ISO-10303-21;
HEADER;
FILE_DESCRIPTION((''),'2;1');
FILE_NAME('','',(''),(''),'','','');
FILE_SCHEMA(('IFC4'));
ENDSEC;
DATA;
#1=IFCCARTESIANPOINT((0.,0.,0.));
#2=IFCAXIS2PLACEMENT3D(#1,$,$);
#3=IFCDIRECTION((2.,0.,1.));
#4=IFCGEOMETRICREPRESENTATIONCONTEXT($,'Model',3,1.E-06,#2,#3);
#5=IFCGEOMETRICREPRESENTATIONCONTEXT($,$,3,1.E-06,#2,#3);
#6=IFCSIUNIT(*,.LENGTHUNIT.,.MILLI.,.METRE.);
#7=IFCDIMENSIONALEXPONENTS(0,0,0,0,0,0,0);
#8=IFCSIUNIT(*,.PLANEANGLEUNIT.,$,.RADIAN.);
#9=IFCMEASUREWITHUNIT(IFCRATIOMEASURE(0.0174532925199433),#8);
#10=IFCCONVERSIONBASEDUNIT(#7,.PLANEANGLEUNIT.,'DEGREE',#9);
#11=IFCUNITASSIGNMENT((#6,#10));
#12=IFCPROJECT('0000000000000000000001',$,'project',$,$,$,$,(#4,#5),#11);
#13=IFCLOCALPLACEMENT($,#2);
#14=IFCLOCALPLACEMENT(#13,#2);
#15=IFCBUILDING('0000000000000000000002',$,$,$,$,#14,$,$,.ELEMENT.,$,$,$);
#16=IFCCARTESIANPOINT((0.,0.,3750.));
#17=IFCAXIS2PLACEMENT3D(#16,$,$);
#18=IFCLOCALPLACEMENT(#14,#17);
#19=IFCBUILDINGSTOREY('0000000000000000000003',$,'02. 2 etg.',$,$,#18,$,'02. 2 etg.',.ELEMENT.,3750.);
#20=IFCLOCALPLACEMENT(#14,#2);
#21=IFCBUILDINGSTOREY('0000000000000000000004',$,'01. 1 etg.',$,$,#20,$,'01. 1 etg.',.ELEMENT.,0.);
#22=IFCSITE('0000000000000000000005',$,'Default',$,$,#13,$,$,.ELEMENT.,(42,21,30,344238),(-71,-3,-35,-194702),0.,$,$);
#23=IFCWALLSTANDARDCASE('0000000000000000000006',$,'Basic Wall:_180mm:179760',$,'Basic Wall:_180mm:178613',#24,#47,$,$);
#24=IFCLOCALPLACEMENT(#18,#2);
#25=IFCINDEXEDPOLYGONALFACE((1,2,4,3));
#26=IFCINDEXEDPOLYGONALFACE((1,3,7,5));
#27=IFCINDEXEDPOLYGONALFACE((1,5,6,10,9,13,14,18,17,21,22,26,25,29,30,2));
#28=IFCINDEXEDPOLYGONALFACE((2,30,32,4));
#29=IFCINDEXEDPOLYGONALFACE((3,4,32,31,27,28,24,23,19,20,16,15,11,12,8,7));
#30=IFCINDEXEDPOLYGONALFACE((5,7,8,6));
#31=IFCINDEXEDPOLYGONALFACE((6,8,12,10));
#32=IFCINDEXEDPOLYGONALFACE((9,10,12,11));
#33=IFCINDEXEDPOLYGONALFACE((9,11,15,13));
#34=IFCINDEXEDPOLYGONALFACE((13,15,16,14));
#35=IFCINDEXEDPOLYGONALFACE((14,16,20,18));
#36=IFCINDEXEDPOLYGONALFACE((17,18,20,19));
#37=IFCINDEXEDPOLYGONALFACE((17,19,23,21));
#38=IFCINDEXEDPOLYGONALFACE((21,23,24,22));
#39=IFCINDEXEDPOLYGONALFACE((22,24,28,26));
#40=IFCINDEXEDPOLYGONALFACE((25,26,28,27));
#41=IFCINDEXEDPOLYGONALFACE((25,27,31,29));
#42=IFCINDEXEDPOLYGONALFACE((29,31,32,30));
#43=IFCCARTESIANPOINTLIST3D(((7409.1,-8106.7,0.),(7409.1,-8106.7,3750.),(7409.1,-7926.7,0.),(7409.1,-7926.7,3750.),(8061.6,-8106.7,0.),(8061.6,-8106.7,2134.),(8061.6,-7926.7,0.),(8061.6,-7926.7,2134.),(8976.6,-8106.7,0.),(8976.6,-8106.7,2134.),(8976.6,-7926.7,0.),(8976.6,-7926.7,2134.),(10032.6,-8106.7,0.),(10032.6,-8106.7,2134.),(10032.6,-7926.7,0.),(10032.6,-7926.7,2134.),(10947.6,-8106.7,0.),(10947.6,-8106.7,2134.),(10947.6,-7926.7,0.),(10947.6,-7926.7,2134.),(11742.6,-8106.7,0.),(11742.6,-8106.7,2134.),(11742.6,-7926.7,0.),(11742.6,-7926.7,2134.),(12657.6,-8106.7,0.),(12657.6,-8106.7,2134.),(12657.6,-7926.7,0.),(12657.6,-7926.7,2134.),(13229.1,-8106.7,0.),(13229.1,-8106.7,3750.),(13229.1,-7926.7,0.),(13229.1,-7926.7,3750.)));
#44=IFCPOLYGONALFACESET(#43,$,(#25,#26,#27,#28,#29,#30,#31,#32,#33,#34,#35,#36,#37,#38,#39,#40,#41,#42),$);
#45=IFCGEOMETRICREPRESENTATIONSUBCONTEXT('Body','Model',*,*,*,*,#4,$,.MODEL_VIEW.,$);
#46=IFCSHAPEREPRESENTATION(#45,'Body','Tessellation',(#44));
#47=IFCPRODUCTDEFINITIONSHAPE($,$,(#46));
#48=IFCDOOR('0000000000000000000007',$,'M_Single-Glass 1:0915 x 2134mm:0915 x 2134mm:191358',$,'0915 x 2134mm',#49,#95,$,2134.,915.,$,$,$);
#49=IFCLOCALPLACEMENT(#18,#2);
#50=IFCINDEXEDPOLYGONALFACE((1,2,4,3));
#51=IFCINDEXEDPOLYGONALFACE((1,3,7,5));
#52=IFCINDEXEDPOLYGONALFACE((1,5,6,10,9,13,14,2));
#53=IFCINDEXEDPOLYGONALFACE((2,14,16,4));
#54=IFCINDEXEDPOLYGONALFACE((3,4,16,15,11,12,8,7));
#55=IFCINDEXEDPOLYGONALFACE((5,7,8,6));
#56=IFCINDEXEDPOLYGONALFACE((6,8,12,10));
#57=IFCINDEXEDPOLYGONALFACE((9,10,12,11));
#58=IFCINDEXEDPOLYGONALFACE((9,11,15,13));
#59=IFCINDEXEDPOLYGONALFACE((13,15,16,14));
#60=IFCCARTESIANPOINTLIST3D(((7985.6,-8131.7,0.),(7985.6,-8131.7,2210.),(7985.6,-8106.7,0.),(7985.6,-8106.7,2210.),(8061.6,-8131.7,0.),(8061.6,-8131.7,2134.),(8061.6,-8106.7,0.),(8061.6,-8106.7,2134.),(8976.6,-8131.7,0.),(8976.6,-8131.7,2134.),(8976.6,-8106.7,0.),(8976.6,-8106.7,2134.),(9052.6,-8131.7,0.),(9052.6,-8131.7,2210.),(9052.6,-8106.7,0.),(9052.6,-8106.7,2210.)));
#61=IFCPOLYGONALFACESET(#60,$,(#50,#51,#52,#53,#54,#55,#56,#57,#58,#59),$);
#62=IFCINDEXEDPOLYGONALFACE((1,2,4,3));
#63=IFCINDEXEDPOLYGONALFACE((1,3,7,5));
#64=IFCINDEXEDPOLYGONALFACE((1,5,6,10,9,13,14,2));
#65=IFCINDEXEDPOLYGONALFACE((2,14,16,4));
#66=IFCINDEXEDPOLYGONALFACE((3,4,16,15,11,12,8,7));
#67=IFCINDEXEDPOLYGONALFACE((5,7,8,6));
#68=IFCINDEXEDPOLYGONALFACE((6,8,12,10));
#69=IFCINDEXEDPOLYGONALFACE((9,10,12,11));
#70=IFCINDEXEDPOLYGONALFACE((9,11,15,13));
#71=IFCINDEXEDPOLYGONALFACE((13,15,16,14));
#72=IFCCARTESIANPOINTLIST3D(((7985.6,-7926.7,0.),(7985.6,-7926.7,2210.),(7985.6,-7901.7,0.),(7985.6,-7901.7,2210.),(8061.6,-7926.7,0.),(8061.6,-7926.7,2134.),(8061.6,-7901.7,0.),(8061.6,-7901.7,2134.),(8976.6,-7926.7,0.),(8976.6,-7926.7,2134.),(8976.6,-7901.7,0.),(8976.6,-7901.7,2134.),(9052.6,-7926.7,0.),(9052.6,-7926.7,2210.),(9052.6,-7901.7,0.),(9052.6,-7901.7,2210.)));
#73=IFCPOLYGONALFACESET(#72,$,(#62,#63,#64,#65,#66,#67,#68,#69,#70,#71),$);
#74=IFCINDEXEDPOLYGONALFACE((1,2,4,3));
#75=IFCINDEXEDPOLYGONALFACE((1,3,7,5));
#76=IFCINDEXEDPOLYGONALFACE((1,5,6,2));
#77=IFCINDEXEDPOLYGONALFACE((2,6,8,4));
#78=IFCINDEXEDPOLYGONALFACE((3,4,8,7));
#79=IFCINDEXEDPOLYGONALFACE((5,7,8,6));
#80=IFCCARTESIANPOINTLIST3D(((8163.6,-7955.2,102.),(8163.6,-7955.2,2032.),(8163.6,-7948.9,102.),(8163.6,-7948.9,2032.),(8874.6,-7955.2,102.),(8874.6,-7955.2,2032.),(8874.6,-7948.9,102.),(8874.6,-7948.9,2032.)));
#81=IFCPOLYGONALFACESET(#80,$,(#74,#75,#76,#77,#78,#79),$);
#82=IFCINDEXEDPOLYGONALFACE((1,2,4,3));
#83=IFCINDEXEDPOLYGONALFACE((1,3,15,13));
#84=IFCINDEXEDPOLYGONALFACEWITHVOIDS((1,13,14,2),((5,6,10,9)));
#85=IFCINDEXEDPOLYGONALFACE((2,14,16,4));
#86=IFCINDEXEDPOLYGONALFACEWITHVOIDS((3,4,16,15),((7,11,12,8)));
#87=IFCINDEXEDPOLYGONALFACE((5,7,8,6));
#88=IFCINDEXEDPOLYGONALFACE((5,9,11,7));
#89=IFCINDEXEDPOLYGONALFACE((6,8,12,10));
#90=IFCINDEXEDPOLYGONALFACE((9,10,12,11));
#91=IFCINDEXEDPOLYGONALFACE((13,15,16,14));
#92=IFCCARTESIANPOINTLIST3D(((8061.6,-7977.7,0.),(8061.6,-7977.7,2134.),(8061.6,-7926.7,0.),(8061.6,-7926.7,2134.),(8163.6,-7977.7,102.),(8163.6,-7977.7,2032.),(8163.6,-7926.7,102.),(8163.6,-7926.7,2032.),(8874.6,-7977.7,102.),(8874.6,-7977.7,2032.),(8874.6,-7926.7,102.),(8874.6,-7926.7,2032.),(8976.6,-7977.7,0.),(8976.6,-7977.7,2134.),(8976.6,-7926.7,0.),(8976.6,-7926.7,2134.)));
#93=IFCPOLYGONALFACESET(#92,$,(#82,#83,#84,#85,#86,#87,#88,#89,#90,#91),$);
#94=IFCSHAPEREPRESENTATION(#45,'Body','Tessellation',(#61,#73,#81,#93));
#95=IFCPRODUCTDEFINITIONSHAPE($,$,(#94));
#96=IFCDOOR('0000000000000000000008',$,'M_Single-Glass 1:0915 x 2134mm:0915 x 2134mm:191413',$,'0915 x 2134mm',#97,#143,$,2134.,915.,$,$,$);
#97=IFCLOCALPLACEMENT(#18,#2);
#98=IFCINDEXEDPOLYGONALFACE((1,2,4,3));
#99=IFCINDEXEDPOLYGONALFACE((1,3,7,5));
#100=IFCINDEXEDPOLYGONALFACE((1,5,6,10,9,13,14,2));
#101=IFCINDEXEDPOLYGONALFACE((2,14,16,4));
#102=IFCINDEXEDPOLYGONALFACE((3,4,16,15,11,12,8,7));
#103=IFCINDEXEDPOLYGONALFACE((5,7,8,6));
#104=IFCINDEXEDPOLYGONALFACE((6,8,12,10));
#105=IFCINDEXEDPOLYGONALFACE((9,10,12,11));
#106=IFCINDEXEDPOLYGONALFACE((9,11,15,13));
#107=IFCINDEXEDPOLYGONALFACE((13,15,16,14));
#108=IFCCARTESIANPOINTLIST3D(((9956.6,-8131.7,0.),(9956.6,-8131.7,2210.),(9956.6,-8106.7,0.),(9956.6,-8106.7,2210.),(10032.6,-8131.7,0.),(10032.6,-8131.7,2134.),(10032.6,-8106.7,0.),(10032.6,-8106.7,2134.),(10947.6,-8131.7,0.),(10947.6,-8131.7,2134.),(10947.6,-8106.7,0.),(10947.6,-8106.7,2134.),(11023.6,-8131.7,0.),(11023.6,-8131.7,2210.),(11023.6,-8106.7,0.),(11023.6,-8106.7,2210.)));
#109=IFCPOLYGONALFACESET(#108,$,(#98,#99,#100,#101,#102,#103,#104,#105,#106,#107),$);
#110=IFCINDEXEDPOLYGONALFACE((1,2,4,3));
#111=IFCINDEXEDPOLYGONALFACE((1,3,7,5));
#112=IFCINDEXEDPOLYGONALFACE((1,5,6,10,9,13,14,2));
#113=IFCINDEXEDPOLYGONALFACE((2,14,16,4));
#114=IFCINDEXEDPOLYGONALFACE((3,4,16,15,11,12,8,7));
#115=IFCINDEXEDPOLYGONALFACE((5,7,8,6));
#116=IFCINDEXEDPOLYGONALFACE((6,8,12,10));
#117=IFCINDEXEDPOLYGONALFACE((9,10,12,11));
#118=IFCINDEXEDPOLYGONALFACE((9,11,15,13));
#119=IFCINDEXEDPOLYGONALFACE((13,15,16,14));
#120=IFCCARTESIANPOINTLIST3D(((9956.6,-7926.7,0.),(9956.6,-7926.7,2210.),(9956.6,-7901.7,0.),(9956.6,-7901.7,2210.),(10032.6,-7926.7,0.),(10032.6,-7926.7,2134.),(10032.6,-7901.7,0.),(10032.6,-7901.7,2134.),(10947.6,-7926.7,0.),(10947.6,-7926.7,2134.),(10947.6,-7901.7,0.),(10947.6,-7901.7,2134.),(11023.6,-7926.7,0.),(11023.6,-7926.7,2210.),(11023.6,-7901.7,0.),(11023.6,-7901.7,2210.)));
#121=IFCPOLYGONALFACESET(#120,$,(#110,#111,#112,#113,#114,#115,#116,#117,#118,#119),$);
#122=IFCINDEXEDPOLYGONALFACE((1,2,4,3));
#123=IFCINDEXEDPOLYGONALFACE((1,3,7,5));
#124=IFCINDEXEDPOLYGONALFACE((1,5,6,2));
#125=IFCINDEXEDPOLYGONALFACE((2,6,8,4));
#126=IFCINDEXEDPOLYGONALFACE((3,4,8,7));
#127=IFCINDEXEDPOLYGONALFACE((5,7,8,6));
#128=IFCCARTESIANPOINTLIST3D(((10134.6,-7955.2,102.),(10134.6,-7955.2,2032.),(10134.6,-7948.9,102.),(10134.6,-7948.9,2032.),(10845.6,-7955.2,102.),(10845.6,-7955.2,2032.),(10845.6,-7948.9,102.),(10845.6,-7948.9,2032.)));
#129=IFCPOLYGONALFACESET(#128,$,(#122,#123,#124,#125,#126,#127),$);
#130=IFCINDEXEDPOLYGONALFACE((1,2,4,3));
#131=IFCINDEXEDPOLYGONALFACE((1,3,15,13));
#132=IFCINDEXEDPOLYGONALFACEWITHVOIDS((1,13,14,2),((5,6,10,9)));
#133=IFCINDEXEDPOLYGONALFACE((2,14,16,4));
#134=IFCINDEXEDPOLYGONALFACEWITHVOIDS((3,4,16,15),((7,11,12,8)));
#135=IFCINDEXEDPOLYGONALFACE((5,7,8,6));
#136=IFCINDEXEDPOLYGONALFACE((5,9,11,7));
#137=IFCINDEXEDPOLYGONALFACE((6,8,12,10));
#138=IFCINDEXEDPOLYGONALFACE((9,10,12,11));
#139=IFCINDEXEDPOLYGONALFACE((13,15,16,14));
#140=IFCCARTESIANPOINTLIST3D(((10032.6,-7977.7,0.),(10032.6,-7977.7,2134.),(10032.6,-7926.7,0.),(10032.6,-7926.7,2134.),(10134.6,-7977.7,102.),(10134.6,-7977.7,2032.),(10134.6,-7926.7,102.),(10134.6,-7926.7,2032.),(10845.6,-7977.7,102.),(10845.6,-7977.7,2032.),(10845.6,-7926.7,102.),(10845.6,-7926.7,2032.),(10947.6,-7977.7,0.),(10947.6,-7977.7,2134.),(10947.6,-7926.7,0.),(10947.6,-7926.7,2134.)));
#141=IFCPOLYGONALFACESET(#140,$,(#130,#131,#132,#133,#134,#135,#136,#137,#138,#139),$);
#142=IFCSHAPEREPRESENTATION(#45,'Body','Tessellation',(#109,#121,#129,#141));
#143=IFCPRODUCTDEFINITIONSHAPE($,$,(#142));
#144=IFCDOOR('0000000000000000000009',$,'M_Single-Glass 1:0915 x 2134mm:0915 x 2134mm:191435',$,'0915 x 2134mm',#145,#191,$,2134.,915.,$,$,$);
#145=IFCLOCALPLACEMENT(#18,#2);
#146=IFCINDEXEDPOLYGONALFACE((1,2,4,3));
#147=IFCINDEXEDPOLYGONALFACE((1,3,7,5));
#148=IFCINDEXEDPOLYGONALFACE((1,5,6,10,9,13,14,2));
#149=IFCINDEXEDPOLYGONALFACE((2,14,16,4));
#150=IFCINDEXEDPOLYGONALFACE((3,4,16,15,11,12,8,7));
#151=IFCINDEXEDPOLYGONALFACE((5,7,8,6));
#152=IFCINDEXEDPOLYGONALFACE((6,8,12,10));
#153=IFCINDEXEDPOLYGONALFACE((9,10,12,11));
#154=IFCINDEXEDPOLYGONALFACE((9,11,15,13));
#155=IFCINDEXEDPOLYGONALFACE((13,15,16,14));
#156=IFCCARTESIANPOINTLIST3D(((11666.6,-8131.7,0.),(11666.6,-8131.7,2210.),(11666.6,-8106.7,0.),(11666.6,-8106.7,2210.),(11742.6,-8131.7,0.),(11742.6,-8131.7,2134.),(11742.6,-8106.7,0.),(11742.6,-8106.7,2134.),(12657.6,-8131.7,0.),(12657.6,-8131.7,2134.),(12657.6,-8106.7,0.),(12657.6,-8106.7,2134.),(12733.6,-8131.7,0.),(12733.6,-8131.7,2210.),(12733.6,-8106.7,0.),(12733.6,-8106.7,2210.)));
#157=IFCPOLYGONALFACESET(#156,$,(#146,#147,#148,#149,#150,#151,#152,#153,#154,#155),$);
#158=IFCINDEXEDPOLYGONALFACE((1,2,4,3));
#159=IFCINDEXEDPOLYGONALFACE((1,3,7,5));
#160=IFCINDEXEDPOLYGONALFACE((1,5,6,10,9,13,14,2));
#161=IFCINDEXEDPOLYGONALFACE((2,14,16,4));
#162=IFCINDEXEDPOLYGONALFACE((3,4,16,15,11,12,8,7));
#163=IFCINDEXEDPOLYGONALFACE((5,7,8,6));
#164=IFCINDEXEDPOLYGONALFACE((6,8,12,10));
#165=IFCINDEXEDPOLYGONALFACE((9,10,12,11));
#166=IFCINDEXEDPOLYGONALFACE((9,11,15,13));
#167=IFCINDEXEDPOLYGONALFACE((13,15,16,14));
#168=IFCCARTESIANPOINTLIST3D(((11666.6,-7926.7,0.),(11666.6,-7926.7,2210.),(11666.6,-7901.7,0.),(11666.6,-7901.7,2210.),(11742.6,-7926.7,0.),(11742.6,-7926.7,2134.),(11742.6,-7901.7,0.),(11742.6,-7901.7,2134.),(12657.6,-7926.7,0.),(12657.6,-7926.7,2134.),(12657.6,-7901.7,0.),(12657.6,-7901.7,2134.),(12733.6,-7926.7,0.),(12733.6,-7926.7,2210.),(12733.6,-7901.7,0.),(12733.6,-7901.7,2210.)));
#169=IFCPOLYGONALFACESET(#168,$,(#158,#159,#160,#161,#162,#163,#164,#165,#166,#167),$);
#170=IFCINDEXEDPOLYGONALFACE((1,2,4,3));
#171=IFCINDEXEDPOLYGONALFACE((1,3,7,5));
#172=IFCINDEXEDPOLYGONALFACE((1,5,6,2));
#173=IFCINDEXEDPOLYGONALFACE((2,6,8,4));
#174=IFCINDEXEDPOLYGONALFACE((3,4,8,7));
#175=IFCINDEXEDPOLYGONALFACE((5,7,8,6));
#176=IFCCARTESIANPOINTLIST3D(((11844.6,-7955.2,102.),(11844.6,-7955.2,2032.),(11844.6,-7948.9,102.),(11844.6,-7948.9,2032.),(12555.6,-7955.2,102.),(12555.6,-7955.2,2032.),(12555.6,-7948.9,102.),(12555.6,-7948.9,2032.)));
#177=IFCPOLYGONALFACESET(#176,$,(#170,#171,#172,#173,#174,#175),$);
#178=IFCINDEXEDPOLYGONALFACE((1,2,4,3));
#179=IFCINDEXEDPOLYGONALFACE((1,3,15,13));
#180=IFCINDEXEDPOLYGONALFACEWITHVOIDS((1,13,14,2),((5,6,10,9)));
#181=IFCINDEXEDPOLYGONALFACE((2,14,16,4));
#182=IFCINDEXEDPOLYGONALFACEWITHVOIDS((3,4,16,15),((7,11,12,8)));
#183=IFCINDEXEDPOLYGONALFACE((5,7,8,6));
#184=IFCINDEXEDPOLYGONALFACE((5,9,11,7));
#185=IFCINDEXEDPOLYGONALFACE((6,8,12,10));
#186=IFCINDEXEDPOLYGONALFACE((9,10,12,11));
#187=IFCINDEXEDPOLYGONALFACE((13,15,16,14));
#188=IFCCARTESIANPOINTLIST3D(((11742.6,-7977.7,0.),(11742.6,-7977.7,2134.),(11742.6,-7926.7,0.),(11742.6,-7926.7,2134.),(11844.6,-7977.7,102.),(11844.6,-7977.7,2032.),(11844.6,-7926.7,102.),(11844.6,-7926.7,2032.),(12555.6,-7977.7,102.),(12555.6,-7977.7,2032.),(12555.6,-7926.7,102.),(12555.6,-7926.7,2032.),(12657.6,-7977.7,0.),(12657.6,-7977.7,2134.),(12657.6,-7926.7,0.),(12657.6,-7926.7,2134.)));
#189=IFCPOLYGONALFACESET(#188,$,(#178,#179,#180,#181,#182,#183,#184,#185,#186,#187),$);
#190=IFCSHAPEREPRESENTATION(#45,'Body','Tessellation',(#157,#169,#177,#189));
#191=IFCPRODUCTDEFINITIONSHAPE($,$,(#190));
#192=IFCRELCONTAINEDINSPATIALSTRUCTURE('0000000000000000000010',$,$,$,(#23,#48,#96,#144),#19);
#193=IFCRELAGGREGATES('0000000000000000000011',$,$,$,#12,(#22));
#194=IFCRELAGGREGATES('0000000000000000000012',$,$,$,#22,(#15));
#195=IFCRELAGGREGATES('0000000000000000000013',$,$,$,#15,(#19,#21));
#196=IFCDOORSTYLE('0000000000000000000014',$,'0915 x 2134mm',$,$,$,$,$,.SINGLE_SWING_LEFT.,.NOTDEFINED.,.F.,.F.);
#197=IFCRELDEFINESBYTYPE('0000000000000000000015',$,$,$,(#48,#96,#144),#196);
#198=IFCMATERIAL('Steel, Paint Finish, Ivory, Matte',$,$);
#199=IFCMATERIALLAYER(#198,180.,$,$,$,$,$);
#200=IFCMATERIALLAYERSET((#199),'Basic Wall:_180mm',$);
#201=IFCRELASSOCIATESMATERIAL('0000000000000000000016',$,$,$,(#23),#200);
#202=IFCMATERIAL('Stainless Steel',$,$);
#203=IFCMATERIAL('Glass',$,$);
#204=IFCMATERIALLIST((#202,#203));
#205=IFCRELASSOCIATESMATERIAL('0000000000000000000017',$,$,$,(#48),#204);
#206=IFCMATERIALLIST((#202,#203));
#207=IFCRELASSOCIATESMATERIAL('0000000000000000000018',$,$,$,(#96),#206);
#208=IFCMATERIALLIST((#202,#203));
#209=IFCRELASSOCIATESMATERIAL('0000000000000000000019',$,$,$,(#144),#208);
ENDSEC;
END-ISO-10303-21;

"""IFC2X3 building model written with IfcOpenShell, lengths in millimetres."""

from ifc_helpers import new_model, entity, si_unit, converted_unit, direction, frame, frame_2d, origin, place, context, subcontext, project, spatial, polyline, rectangle, outline, extrude, source, transform, mapped, material, material_list, layer, layer_set, layer_usage, type_object, type_shapes, element, fill, save


model = new_model("IFC2X3")

# Units and contexts
model_context = context("Model", 3, precision=1e-06, world=origin(), true_north=direction((2.0, 0.0, 1.0)))
context_of_model = context(None, 3, precision=1e-06, world=origin(), true_north=direction((2.0, 0.0, 1.0)))
body_context = subcontext(model_context, "Body", "Model", "MODEL_VIEW")
ifc_project = project(units=[si_unit("LENGTHUNIT", "METRE", prefix="MILLI"), converted_unit("PLANEANGLEUNIT", "DEGREE", entity("IfcRatioMeasure", 0.0174532925199433), si_unit("PLANEANGLEUNIT", "RADIAN"), dimensions=[0, 0, 0, 0, 0, 0, 0])], contexts=[model_context, context_of_model])

# Site, building, storey
site_placement = place(None, origin())
site = spatial("IfcSite", under=ifc_project, at=site_placement, Name="Default", CompositionType="ELEMENT", RefLatitude=(42, 21, 30, 344238), RefLongitude=(-71, -3, -35, -194702), RefElevation=0.0)
building_placement = place(site_placement, origin())
building = spatial("IfcBuilding", under=site, at=building_placement, CompositionType="ELEMENT")
storey_1_placement = place(building_placement, frame((0.0, 0.0, 3750.0)))
storey_1 = spatial("IfcBuildingStorey", under=building, at=storey_1_placement, Name="02. 2 etg.", LongName="02. 2 etg.", CompositionType="ELEMENT", Elevation=3750.0)

# Shared definitions
ifc_material_1 = material(Name="Steel, Paint Finish, Ivory, Matte")
ifc_material_2 = material(Name="Stainless Steel")
ifc_material_3 = material(Name="Glass")

# Wall, openings, doors
ifc_layer_1 = layer(ifc_material_1, 180.0)
ifc_layer_set_1 = layer_set([ifc_layer_1], Name="Basic Wall:_180mm")
ifc_layer_usage_1 = layer_usage(ifc_layer_set_1, "AXIS2", "NEGATIVE", 90.0)
wall_1_placement = place(storey_1_placement, frame((13229.1, -8016.7, 0.0), z_axis=(0.0, 0.0, 1.0), x_axis=(-1.0, 0.0, 0.0)))
wall_1 = element("IfcWallStandardCase", 1, at=wall_1_placement, inside=storey_1, material=ifc_layer_usage_1, Name="Basic Wall:_180mm:179760", ObjectType="Basic Wall:_180mm:178613", context=body_context, shape_type="SweptSolid", body=[
    extrude(rectangle(XDim=5820.0, YDim=180.0, at=frame_2d((2910.0, 0.0), x_axis=(-1.0, 0.0))), origin(), (0.0, 0.0, 1.0), 3750.0),
])
opening_1_placement = place(wall_1_placement, frame((5167.5, 90.0, 0.0)))
opening_1 = element("IfcOpeningElement", 2, at=opening_1_placement, cuts=wall_1, ObjectType="Opening", context=body_context, shape_type="SweptSolid", body=[
    extrude(rectangle(XDim=915.0, YDim=2134.0, at=frame_2d((1067.0, 457.5), x_axis=(0.0, -1.0))), frame((0.0, 0.0, 0.0), z_axis=(0.0, -1.0, 0.0), x_axis=(0.0, 0.0, 1.0)), (0.0, 0.0, 1.0), 180.0),
])
opening_2_placement = place(wall_1_placement, frame((3196.5, 90.0, 0.0)))
opening_2 = element("IfcOpeningElement", 3, at=opening_2_placement, cuts=wall_1, ObjectType="Opening", context=body_context, shape_type="SweptSolid", body=[
    extrude(rectangle(XDim=915.0, YDim=2134.0, at=frame_2d((1067.0, 457.5), x_axis=(0.0, -1.0))), frame((0.0, 0.0, 0.0), z_axis=(0.0, -1.0, 0.0), x_axis=(0.0, 0.0, 1.0)), (0.0, 0.0, 1.0), 180.0),
])
opening_3_placement = place(wall_1_placement, frame((1486.5, 90.0, 0.0)))
opening_3 = element("IfcOpeningElement", 4, at=opening_3_placement, cuts=wall_1, ObjectType="Opening", context=body_context, shape_type="SweptSolid", body=[
    extrude(rectangle(XDim=915.0, YDim=2134.0, at=frame_2d((1067.0, 457.5), x_axis=(0.0, -1.0))), frame((0.0, 0.0, 0.0), z_axis=(0.0, -1.0, 0.0), x_axis=(0.0, 0.0, 1.0)), (0.0, 0.0, 1.0), 180.0),
])
ifc_material_list_1 = material_list([ifc_material_2, ifc_material_3])
door_style_1 = type_object("IfcDoorStyle", Name="0915 x 2134mm", ConstructionType="NOTDEFINED", OperationType="SINGLE_SWING_LEFT", ParameterTakesPrecedence=False, Sizeable=False)
shared_shape_1 = source(origin(), body_context, "Body", "SweptSolid", [
    extrude(outline(polyline([(-457.5, -1048.0), (-457.5, 1086.0), (-533.5, 1086.0), (-533.5, -1124.0), (533.5, -1124.0), (533.5, 1086.0), (457.5, 1086.0), (457.5, -1048.0), (-457.5, -1048.0)])), frame((457.5, 0.0, 1086.0), z_axis=(0.0, 1.0, 0.0), x_axis=(1.0, 0.0, 0.0)), (0.0, 0.0, -1.0), 25.0),
    extrude(outline(polyline([(-457.5, -1048.0), (-457.5, 1086.0), (-533.5, 1086.0), (-533.5, -1124.0), (533.5, -1124.0), (533.5, 1086.0), (457.5, 1086.0), (457.5, -1048.0), (-457.5, -1048.0)])), frame((457.5, 205.0, 1086.0), z_axis=(0.0, 1.0, 0.0), x_axis=(1.0, 0.0, 0.0)), (0.0, 0.0, -1.0), 25.0),
    extrude(rectangle(XDim=711.0, YDim=6.3, at=frame_2d((0.0, 0.0), x_axis=(1.0, 0.0))), frame((457.5, 154.6, 102.0)), (0.0, 0.0, 1.0), 1930.0),
    extrude(outline(polyline([(-1067.0, -457.5), (1067.0, -457.5), (1067.0, 457.5), (-1067.0, 457.5), (-1067.0, -457.5)]), holes=[polyline([(-965.0, 355.5), (965.0, 355.5), (965.0, -355.5), (-965.0, -355.5), (-965.0, 355.5)])]), frame((457.5, 180.0, 1067.0), z_axis=(0.0, -1.0, 0.0), x_axis=(0.0, 0.0, -1.0)), (0.0, 0.0, 1.0), 51.0),
])
type_shapes(door_style_1, [shared_shape_1])
door_1_placement = place(opening_1_placement, frame((0.0, 0.0, 0.0), z_axis=(0.0, 0.0, 1.0), x_axis=(-1.0, 0.0, 0.0)))
door_1 = element("IfcDoor", 5, at=door_1_placement, inside=storey_1, type_object=door_style_1, material=ifc_material_list_1, Name="M_Single-Glass 1:0915 x 2134mm:0915 x 2134mm:191358", ObjectType="0915 x 2134mm", OverallHeight=2134.0, OverallWidth=915.0, context=body_context, shape_type="MappedRepresentation", body=[
    mapped(shared_shape_1, transform((0.0, 0.0, 0.0), scale=1.0)),
])
fill(opening_1, door_1)
ifc_material_list_2 = material_list([ifc_material_2, ifc_material_3])
door_2_placement = place(opening_2_placement, frame((0.0, 0.0, 0.0), z_axis=(0.0, 0.0, 1.0), x_axis=(-1.0, 0.0, 0.0)))
door_2 = element("IfcDoor", 6, at=door_2_placement, inside=storey_1, type_object=door_style_1, material=ifc_material_list_2, Name="M_Single-Glass 1:0915 x 2134mm:0915 x 2134mm:191413", ObjectType="0915 x 2134mm", OverallHeight=2134.0, OverallWidth=915.0, context=body_context, shape_type="MappedRepresentation", body=[
    mapped(shared_shape_1, transform((0.0, 0.0, 0.0), scale=1.0)),
])
fill(opening_2, door_2)
ifc_material_list_3 = material_list([ifc_material_2, ifc_material_3])
door_3_placement = place(opening_3_placement, frame((0.0, 0.0, 0.0), z_axis=(0.0, 0.0, 1.0), x_axis=(-1.0, 0.0, 0.0)))
door_3 = element("IfcDoor", 7, at=door_3_placement, inside=storey_1, type_object=door_style_1, material=ifc_material_list_3, Name="M_Single-Glass 1:0915 x 2134mm:0915 x 2134mm:191435", ObjectType="0915 x 2134mm", OverallHeight=2134.0, OverallWidth=915.0, context=body_context, shape_type="MappedRepresentation", body=[
    mapped(shared_shape_1, transform((0.0, 0.0, 0.0), scale=1.0)),
])
fill(opening_3, door_3)

# Shared definitions
storey_2_placement = place(building_placement, origin())
storey_2 = spatial("IfcBuildingStorey", under=building, at=storey_2_placement, Name="01. 1 etg.", LongName="01. 1 etg.", CompositionType="ELEMENT", Elevation=0.0)

save(model, "model.ifc")
